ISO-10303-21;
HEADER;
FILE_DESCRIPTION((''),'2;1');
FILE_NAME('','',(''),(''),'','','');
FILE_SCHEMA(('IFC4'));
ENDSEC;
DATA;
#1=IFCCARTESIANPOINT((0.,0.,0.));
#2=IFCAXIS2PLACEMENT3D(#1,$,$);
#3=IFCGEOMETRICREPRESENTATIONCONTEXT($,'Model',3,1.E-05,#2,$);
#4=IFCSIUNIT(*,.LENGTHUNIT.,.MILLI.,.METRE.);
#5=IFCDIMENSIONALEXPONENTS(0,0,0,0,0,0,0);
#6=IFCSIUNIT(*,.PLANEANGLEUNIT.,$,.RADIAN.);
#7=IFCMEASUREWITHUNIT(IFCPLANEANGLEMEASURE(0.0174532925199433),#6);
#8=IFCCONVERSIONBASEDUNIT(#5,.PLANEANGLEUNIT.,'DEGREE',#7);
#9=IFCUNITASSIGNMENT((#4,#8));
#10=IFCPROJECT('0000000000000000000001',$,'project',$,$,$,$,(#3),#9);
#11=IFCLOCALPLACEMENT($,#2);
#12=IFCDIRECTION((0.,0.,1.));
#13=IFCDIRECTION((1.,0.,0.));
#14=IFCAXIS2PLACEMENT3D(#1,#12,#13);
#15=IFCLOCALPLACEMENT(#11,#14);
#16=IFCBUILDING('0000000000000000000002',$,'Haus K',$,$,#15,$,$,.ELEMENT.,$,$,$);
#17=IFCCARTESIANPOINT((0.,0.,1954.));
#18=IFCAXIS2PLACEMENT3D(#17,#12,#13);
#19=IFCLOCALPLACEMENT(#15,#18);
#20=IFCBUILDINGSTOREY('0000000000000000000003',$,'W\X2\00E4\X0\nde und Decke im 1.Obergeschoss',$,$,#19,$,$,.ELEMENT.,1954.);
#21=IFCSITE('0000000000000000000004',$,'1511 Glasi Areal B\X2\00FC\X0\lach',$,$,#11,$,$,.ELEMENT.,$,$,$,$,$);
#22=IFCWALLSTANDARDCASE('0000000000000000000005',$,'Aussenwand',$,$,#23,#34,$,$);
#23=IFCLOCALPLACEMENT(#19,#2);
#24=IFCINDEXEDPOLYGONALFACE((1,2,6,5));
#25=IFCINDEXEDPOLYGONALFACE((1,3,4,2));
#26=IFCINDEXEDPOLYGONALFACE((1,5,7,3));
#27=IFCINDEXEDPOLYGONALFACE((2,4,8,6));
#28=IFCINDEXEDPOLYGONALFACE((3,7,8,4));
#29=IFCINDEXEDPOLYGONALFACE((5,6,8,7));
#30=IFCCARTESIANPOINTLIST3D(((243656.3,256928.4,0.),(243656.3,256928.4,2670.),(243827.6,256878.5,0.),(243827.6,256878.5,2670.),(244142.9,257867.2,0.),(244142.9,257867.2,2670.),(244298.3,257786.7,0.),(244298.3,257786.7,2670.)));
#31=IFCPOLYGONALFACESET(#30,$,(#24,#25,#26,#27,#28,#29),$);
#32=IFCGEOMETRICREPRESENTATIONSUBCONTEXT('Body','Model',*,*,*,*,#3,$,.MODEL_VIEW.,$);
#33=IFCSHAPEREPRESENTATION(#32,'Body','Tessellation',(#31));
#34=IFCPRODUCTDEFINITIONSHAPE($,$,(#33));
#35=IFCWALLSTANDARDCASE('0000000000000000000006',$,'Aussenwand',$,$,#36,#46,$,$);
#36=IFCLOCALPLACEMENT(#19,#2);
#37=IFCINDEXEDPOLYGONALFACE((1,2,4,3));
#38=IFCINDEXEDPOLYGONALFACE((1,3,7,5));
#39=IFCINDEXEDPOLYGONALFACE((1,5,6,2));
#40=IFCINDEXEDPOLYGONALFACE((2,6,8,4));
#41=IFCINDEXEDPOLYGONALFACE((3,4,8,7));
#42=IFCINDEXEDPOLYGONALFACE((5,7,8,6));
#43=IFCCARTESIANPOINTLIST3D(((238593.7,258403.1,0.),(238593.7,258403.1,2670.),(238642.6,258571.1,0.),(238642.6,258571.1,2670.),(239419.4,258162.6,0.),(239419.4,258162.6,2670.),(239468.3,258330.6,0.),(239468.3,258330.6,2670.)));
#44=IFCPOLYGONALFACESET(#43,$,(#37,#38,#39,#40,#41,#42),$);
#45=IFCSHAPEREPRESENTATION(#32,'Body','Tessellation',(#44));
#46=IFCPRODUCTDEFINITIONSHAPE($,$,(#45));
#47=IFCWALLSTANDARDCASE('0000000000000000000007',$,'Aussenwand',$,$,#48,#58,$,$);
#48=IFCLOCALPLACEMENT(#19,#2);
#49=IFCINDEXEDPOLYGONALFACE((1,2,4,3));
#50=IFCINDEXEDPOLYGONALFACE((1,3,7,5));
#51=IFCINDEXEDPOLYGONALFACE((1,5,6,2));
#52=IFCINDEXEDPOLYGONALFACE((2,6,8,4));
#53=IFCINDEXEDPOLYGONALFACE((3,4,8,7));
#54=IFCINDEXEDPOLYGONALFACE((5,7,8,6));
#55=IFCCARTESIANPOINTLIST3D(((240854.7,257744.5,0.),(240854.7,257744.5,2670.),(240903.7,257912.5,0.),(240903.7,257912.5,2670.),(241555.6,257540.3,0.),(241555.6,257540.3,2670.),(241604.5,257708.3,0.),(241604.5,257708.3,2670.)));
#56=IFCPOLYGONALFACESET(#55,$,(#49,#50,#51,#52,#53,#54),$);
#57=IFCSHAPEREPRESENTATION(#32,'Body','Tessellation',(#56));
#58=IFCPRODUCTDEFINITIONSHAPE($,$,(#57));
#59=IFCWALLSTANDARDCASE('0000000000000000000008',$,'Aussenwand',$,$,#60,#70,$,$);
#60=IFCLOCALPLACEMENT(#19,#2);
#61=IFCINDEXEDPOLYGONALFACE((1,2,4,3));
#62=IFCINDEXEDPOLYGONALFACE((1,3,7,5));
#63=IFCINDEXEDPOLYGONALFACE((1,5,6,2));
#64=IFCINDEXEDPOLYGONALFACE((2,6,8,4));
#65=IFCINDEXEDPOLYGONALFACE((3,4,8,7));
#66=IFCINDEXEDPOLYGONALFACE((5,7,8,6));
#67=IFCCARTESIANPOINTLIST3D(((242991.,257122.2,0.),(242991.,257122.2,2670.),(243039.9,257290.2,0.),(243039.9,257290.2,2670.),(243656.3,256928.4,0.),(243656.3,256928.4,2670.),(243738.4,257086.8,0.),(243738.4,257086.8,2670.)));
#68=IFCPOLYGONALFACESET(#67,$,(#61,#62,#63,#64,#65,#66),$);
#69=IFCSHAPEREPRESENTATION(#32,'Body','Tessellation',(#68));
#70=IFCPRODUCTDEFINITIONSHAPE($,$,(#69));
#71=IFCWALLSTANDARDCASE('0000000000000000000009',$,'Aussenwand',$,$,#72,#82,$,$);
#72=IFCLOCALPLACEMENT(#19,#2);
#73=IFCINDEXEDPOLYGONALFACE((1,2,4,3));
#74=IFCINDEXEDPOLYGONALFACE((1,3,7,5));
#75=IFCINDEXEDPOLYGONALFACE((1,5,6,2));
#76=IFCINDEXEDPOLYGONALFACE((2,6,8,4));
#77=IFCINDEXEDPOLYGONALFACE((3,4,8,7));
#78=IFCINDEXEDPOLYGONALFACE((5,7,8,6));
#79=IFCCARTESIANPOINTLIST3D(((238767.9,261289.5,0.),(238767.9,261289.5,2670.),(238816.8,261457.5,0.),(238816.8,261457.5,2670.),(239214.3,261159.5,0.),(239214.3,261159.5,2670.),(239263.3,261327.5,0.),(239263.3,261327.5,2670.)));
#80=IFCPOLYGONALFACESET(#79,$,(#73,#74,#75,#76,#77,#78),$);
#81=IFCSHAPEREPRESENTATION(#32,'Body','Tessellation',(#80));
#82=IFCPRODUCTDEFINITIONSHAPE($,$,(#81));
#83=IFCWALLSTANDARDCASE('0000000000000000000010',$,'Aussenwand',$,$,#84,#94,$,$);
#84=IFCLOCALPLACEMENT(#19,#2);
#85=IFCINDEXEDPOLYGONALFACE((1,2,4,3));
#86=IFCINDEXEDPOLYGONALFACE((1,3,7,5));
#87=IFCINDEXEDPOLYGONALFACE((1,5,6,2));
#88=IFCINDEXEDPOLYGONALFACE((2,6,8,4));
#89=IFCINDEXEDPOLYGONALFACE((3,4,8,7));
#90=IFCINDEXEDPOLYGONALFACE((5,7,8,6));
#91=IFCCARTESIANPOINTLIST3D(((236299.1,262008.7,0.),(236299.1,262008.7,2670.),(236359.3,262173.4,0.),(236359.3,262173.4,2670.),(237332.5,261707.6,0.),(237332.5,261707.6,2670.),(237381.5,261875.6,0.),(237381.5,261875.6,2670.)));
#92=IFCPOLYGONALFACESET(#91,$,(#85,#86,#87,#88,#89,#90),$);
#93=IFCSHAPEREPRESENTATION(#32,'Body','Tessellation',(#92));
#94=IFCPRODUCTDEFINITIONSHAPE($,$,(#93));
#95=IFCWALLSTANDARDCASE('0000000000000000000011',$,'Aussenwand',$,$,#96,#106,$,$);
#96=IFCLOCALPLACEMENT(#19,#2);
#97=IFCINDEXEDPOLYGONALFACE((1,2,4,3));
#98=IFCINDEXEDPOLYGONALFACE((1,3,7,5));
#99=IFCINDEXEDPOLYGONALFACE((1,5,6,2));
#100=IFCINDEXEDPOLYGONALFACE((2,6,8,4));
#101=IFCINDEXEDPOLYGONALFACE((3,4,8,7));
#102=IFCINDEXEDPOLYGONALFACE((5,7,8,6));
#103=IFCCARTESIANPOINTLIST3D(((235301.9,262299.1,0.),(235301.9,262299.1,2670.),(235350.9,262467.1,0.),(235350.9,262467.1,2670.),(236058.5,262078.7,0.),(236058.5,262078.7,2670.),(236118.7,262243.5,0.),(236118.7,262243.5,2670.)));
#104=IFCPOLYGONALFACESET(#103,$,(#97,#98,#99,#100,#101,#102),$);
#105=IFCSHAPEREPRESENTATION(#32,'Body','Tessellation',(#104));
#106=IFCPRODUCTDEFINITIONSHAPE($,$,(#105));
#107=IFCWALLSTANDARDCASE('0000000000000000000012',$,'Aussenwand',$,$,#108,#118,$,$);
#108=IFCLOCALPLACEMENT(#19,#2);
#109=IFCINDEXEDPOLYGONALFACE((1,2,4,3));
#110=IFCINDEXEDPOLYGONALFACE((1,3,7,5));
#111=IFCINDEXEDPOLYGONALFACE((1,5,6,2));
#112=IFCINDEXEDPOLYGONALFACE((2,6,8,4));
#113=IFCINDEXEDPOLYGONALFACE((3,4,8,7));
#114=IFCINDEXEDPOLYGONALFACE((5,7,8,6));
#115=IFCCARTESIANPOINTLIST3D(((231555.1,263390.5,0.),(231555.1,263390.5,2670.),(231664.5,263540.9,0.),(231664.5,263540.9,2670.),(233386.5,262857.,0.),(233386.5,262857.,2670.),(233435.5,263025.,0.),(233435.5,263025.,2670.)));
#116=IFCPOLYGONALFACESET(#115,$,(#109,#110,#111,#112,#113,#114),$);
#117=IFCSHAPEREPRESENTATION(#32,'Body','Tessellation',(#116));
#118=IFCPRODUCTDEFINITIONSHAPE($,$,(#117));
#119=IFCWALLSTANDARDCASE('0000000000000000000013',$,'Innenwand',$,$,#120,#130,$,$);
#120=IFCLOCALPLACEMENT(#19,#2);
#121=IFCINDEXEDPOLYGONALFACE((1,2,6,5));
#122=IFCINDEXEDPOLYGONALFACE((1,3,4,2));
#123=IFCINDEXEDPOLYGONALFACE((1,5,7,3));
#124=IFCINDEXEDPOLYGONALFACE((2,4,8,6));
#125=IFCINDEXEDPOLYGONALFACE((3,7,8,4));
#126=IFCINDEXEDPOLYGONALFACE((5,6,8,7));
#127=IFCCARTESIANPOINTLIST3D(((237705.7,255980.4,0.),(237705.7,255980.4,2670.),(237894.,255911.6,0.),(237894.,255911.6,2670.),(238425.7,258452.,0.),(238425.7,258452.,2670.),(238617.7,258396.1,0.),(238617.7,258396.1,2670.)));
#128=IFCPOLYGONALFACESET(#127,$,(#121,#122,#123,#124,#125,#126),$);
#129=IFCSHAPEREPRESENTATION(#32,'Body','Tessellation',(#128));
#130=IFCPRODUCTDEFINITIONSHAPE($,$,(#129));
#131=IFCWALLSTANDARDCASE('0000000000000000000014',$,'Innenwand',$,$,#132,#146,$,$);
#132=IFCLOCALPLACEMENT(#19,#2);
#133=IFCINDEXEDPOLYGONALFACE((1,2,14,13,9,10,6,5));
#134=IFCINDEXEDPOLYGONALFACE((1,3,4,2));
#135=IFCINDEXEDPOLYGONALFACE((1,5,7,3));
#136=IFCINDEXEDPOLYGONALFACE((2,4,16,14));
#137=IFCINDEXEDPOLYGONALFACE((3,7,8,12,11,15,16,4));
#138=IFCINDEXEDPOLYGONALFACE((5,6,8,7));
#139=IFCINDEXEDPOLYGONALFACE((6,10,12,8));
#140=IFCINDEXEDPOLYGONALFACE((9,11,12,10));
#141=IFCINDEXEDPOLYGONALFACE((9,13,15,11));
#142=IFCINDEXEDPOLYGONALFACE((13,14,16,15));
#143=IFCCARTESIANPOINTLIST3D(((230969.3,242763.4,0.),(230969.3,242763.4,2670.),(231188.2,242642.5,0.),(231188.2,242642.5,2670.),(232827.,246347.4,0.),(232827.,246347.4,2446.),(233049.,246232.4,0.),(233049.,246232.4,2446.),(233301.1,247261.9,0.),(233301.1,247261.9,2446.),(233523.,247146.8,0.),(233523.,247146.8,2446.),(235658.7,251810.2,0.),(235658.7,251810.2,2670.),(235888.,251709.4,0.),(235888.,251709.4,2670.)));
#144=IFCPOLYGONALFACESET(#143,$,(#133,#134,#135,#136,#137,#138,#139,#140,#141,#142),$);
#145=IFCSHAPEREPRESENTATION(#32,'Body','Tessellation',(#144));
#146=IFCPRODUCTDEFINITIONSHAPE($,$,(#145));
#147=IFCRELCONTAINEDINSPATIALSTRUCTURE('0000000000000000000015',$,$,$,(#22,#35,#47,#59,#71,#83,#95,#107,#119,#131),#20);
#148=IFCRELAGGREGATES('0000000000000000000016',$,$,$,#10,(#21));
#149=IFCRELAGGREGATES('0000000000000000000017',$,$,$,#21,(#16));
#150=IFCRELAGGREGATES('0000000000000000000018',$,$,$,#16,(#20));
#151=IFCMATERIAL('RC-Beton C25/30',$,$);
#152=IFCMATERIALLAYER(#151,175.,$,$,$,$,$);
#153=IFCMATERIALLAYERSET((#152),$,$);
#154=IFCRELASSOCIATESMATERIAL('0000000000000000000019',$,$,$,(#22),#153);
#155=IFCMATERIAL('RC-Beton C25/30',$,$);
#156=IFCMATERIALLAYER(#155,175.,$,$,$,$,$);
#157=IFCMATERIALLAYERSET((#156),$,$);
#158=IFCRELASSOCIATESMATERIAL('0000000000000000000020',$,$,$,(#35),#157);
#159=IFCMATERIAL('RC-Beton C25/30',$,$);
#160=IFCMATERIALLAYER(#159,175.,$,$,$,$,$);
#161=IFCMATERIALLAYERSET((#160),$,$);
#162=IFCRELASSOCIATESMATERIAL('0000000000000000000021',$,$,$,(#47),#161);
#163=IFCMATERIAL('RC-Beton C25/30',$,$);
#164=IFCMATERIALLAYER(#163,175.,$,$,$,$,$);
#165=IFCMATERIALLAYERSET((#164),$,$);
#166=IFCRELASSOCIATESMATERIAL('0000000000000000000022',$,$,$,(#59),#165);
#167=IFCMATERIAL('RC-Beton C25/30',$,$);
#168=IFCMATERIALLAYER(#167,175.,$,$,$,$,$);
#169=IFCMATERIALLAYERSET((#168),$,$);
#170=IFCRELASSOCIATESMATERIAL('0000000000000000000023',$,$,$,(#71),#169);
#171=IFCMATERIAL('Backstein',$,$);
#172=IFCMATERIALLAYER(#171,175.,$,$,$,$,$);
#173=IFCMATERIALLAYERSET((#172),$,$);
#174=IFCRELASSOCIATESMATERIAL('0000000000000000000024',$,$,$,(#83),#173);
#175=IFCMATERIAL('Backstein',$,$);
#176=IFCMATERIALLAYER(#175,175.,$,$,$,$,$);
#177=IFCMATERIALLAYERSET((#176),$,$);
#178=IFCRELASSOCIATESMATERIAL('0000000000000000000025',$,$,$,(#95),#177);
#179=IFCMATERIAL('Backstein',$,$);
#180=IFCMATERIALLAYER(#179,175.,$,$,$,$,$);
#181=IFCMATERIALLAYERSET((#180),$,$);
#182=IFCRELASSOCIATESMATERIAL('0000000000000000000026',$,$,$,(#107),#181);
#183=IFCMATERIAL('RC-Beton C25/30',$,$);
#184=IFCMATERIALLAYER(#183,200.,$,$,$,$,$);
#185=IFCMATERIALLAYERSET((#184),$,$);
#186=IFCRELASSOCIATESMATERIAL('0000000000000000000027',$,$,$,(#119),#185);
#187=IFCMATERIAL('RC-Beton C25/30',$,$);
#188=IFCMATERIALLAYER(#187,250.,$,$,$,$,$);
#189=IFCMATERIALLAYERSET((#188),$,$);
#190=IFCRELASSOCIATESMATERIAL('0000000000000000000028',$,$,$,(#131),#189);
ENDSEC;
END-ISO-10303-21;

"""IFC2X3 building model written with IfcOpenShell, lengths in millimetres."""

from ifc_helpers import new_model, entity, si_unit, converted_unit, frame, frame_2d, origin, origin_with_axes, place, context, subcontext, project, spatial, polyline, rectangle, outline, extrude, material, layer, layer_set, layer_usage, element, save


model = new_model("IFC2X3")

# Units and contexts
model_context = context("Model", 3, precision=1e-05, world=origin())
body_context = subcontext(model_context, "Body", "Model", "MODEL_VIEW")
ifc_project = project(units=[si_unit("LENGTHUNIT", "METRE", prefix="MILLI"), converted_unit("PLANEANGLEUNIT", "DEGREE", entity("IfcPlaneAngleMeasure", 0.0174532925199433), si_unit("PLANEANGLEUNIT", "RADIAN"), dimensions=[0, 0, 0, 0, 0, 0, 0])], contexts=[model_context])

# Site, building, storey
site_placement = place(None, origin())
site = spatial("IfcSite", under=ifc_project, at=site_placement, Name="1511 Glasi Areal Bülach", CompositionType="ELEMENT")
building_placement = place(site_placement, origin_with_axes())
building = spatial("IfcBuilding", under=site, at=building_placement, Name="Haus K", CompositionType="ELEMENT")
storey_placement = place(building_placement, frame((0.0, 0.0, 1954.0), z_axis=(0.0, 0.0, 1.0), x_axis=(1.0, 0.0, 0.0)))
storey = spatial("IfcBuildingStorey", under=building, at=storey_placement, Name="Wände und Decke im 1.Obergeschoss", CompositionType="ELEMENT", Elevation=1954.0)

# Walls
ifc_material_1 = material(Name="RC-Beton C25/30")
ifc_layer_1 = layer(ifc_material_1, 175.0)
ifc_layer_set_1 = layer_set([ifc_layer_1])
ifc_layer_usage_1 = layer_usage(ifc_layer_set_1, "AXIS2", "POSITIVE", 0.0)
wall_1_placement = place(storey_placement, frame((244142.9, 257867.2, 0.0), z_axis=(0.0, 0.0, 1.0), x_axis=(-0.4602, -0.887815, 0.0)))
element("IfcWallStandardCase", 1, at=wall_1_placement, inside=storey, material=ifc_layer_usage_1, Name="Aussenwand", context=body_context, shape_type="SweptSolid", body=[
    extrude(outline(polyline([(0.0, 0.0), (1057.4, 0.0), (1022.9, 175.0), (0.0, 175.0), (0.0, 0.0)])), origin_with_axes(), (0.0, 0.0, 1.0), 2670.0),
])
ifc_material_2 = material(Name="RC-Beton C25/30")
ifc_layer_2 = layer(ifc_material_2, 175.0)
ifc_layer_set_2 = layer_set([ifc_layer_2])
ifc_layer_usage_2 = layer_usage(ifc_layer_set_2, "AXIS2", "POSITIVE", 0.0)
wall_2_placement = place(storey_placement, frame((239468.3, 258330.6, 0.0), z_axis=(0.0, 0.0, 1.0), x_axis=(-0.960099, 0.279661, 0.0)))
element("IfcWallStandardCase", 2, at=wall_2_placement, inside=storey, material=ifc_layer_usage_2, Name="Aussenwand", context=body_context, shape_type="SweptSolid", body=[
    extrude(rectangle(XDim=860.0, YDim=175.0, at=frame_2d((430.0, 87.5), x_axis=(1.0, 0.0))), origin_with_axes(), (0.0, 0.0, 1.0), 2670.0),
])
ifc_material_3 = material(Name="RC-Beton C25/30")
ifc_layer_3 = layer(ifc_material_3, 175.0)
ifc_layer_set_3 = layer_set([ifc_layer_3])
ifc_layer_usage_3 = layer_usage(ifc_layer_set_3, "AXIS2", "POSITIVE", 0.0)
wall_3_placement = place(storey_placement, frame((241604.5, 257708.3, 0.0), z_axis=(0.0, 0.0, 1.0), x_axis=(-0.960099, 0.279661, 0.0)))
element("IfcWallStandardCase", 3, at=wall_3_placement, inside=storey, material=ifc_layer_usage_3, Name="Aussenwand", context=body_context, shape_type="SweptSolid", body=[
    extrude(rectangle(XDim=730.0, YDim=175.0, at=frame_2d((365.0, 87.5), x_axis=(1.0, 0.0))), origin_with_axes(), (0.0, 0.0, 1.0), 2670.0),
])
ifc_material_4 = material(Name="RC-Beton C25/30")
ifc_layer_4 = layer(ifc_material_4, 175.0)
ifc_layer_set_4 = layer_set([ifc_layer_4])
ifc_layer_usage_4 = layer_usage(ifc_layer_set_4, "AXIS2", "POSITIVE", 0.0)
wall_4_placement = place(storey_placement, frame((243738.4, 257086.8, 0.0), z_axis=(0.0, 0.0, 1.0), x_axis=(-0.960099, 0.279661, 0.0)))
element("IfcWallStandardCase", 4, at=wall_4_placement, inside=storey, material=ifc_layer_usage_4, Name="Aussenwand", context=body_context, shape_type="SweptSolid", body=[
    extrude(outline(polyline([(0.0, 0.0), (727.5, 0.0), (727.5, 175.0), (34.5, 175.0), (0.0, 0.0)])), origin_with_axes(), (0.0, 0.0, 1.0), 2670.0),
])
ifc_material_5 = material(Name="RC-Beton C25/30")
ifc_layer_5 = layer(ifc_material_5, 175.0)
ifc_layer_set_5 = layer_set([ifc_layer_5])
ifc_layer_usage_5 = layer_usage(ifc_layer_set_5, "AXIS2", "POSITIVE", 0.0)
wall_5_placement = place(storey_placement, frame((239263.3, 261327.5, 0.0), z_axis=(0.0, 0.0, 1.0), x_axis=(-0.960099, 0.279661, 0.0)))
element("IfcWallStandardCase", 5, at=wall_5_placement, inside=storey, material=ifc_layer_usage_5, Name="Aussenwand", context=body_context, shape_type="SweptSolid", body=[
    extrude(rectangle(XDim=465.0, YDim=175.0, at=frame_2d((232.5, 87.5), x_axis=(1.0, 0.0))), origin_with_axes(), (0.0, 0.0, 1.0), 2670.0),
])
ifc_material_6 = material(Name="Backstein")
ifc_layer_6 = layer(ifc_material_6, 175.0)
ifc_layer_set_6 = layer_set([ifc_layer_6])
ifc_layer_usage_6 = layer_usage(ifc_layer_set_6, "AXIS2", "POSITIVE", 0.0)
wall_6_placement = place(storey_placement, frame((237381.5, 261875.6, 0.0), z_axis=(0.0, 0.0, 1.0), x_axis=(-0.960099, 0.279661, 0.0)))
element("IfcWallStandardCase", 6, at=wall_6_placement, inside=storey, material=ifc_layer_usage_6, Name="Aussenwand", context=body_context, shape_type="SweptSolid", body=[
    extrude(outline(polyline([(0.0, 0.0), (1064.7, 0.0), (1076.4, 175.0), (0.0, 175.0), (0.0, 0.0)])), origin_with_axes(), (0.0, 0.0, 1.0), 2670.0),
])
ifc_material_7 = material(Name="Backstein")
ifc_layer_7 = layer(ifc_material_7, 175.0)
ifc_layer_set_7 = layer_set([ifc_layer_7])
ifc_layer_usage_7 = layer_usage(ifc_layer_set_7, "AXIS2", "POSITIVE", 0.0)
wall_7_placement = place(storey_placement, frame((236118.7, 262243.5, 0.0), z_axis=(0.0, 0.0, 1.0), x_axis=(-0.960099, 0.279661, 0.0)))
element("IfcWallStandardCase", 7, at=wall_7_placement, inside=storey, material=ifc_layer_usage_7, Name="Aussenwand", context=body_context, shape_type="SweptSolid", body=[
    extrude(outline(polyline([(0.0, 0.0), (799.8, 0.0), (799.8, 175.0), (11.7, 175.0), (0.0, 0.0)])), origin_with_axes(), (0.0, 0.0, 1.0), 2670.0),
])
ifc_material_8 = material(Name="Backstein")
ifc_layer_8 = layer(ifc_material_8, 175.0)
ifc_layer_set_8 = layer_set([ifc_layer_8])
ifc_layer_usage_8 = layer_usage(ifc_layer_set_8, "AXIS2", "POSITIVE", 0.0)
wall_8_placement = place(storey_placement, frame((233435.5, 263025.0, 0.0), z_axis=(0.0, 0.0, 1.0), x_axis=(-0.960099, 0.279661, 0.0)))
element("IfcWallStandardCase", 8, at=wall_8_placement, inside=storey, material=ifc_layer_usage_8, Name="Aussenwand", context=body_context, shape_type="SweptSolid", body=[
    extrude(outline(polyline([(0.0, 0.0), (1844.5, 0.0), (1907.6, 175.0), (0.0, 175.0), (0.0, 0.0)])), origin_with_axes(), (0.0, 0.0, 1.0), 2670.0),
])
ifc_material_9 = material(Name="RC-Beton C25/30")
ifc_layer_9 = layer(ifc_material_9, 200.0)
ifc_layer_set_9 = layer_set([ifc_layer_9])
ifc_layer_usage_9 = layer_usage(ifc_layer_set_9, "AXIS2", "POSITIVE", 0.0)
wall_9_placement = place(storey_placement, frame((238425.7, 258452.0, 0.0), z_axis=(0.0, 0.0, 1.0), x_axis=(-0.279661, -0.960099, 0.0)))
element("IfcWallStandardCase", 9, at=wall_9_placement, inside=storey, material=ifc_layer_usage_9, Name="Innenwand", context=body_context, shape_type="SweptSolid", body=[
    extrude(outline(polyline([(0.0, 0.0), (2574.3, 0.0), (2587.7, 200.0), (0.0, 200.0), (0.0, 0.0)])), origin_with_axes(), (0.0, 0.0, 1.0), 2670.0),
])

# Wall, opening
ifc_material_10 = material(Name="RC-Beton C25/30")
ifc_layer_10 = layer(ifc_material_10, 250.0)
ifc_layer_set_10 = layer_set([ifc_layer_10])
ifc_layer_usage_10 = layer_usage(ifc_layer_set_10, "AXIS2", "POSITIVE", 0.0)
wall_10_placement = place(storey_placement, frame((235658.7, 251810.2, 0.0), z_axis=(0.0, 0.0, 1.0), x_axis=(-0.4602, -0.887815, 0.0)))
wall_10 = element("IfcWallStandardCase", 10, at=wall_10_placement, inside=storey, material=ifc_layer_usage_10, Name="Innenwand", context=body_context, shape_type="SweptSolid", body=[
    extrude(outline(polyline([(0.0, 0.0), (10190.0, 0.0), (10196.6, 250.0), (-16.0, 250.0), (0.0, 0.0)])), origin_with_axes(), (0.0, 0.0, 1.0), 2670.0),
])
opening_placement = place(wall_10_placement, frame((5123.1, 0.0, 0.0), z_axis=(0.0, 1.0, 0.0), x_axis=(0.0, 0.0, 1.0)))
element("IfcOpeningElement", 11, at=opening_placement, cuts=wall_10, ObjectType="Opening", context=body_context, shape_type="SweptSolid", body=[
    extrude(rectangle(XDim=2446.0, YDim=1030.0, at=frame_2d((1223.0, 515.0), x_axis=(1.0, 0.0))), origin_with_axes(), (0.0, 0.0, 1.0), 250.0),
])

save(model, "model.ifc")
